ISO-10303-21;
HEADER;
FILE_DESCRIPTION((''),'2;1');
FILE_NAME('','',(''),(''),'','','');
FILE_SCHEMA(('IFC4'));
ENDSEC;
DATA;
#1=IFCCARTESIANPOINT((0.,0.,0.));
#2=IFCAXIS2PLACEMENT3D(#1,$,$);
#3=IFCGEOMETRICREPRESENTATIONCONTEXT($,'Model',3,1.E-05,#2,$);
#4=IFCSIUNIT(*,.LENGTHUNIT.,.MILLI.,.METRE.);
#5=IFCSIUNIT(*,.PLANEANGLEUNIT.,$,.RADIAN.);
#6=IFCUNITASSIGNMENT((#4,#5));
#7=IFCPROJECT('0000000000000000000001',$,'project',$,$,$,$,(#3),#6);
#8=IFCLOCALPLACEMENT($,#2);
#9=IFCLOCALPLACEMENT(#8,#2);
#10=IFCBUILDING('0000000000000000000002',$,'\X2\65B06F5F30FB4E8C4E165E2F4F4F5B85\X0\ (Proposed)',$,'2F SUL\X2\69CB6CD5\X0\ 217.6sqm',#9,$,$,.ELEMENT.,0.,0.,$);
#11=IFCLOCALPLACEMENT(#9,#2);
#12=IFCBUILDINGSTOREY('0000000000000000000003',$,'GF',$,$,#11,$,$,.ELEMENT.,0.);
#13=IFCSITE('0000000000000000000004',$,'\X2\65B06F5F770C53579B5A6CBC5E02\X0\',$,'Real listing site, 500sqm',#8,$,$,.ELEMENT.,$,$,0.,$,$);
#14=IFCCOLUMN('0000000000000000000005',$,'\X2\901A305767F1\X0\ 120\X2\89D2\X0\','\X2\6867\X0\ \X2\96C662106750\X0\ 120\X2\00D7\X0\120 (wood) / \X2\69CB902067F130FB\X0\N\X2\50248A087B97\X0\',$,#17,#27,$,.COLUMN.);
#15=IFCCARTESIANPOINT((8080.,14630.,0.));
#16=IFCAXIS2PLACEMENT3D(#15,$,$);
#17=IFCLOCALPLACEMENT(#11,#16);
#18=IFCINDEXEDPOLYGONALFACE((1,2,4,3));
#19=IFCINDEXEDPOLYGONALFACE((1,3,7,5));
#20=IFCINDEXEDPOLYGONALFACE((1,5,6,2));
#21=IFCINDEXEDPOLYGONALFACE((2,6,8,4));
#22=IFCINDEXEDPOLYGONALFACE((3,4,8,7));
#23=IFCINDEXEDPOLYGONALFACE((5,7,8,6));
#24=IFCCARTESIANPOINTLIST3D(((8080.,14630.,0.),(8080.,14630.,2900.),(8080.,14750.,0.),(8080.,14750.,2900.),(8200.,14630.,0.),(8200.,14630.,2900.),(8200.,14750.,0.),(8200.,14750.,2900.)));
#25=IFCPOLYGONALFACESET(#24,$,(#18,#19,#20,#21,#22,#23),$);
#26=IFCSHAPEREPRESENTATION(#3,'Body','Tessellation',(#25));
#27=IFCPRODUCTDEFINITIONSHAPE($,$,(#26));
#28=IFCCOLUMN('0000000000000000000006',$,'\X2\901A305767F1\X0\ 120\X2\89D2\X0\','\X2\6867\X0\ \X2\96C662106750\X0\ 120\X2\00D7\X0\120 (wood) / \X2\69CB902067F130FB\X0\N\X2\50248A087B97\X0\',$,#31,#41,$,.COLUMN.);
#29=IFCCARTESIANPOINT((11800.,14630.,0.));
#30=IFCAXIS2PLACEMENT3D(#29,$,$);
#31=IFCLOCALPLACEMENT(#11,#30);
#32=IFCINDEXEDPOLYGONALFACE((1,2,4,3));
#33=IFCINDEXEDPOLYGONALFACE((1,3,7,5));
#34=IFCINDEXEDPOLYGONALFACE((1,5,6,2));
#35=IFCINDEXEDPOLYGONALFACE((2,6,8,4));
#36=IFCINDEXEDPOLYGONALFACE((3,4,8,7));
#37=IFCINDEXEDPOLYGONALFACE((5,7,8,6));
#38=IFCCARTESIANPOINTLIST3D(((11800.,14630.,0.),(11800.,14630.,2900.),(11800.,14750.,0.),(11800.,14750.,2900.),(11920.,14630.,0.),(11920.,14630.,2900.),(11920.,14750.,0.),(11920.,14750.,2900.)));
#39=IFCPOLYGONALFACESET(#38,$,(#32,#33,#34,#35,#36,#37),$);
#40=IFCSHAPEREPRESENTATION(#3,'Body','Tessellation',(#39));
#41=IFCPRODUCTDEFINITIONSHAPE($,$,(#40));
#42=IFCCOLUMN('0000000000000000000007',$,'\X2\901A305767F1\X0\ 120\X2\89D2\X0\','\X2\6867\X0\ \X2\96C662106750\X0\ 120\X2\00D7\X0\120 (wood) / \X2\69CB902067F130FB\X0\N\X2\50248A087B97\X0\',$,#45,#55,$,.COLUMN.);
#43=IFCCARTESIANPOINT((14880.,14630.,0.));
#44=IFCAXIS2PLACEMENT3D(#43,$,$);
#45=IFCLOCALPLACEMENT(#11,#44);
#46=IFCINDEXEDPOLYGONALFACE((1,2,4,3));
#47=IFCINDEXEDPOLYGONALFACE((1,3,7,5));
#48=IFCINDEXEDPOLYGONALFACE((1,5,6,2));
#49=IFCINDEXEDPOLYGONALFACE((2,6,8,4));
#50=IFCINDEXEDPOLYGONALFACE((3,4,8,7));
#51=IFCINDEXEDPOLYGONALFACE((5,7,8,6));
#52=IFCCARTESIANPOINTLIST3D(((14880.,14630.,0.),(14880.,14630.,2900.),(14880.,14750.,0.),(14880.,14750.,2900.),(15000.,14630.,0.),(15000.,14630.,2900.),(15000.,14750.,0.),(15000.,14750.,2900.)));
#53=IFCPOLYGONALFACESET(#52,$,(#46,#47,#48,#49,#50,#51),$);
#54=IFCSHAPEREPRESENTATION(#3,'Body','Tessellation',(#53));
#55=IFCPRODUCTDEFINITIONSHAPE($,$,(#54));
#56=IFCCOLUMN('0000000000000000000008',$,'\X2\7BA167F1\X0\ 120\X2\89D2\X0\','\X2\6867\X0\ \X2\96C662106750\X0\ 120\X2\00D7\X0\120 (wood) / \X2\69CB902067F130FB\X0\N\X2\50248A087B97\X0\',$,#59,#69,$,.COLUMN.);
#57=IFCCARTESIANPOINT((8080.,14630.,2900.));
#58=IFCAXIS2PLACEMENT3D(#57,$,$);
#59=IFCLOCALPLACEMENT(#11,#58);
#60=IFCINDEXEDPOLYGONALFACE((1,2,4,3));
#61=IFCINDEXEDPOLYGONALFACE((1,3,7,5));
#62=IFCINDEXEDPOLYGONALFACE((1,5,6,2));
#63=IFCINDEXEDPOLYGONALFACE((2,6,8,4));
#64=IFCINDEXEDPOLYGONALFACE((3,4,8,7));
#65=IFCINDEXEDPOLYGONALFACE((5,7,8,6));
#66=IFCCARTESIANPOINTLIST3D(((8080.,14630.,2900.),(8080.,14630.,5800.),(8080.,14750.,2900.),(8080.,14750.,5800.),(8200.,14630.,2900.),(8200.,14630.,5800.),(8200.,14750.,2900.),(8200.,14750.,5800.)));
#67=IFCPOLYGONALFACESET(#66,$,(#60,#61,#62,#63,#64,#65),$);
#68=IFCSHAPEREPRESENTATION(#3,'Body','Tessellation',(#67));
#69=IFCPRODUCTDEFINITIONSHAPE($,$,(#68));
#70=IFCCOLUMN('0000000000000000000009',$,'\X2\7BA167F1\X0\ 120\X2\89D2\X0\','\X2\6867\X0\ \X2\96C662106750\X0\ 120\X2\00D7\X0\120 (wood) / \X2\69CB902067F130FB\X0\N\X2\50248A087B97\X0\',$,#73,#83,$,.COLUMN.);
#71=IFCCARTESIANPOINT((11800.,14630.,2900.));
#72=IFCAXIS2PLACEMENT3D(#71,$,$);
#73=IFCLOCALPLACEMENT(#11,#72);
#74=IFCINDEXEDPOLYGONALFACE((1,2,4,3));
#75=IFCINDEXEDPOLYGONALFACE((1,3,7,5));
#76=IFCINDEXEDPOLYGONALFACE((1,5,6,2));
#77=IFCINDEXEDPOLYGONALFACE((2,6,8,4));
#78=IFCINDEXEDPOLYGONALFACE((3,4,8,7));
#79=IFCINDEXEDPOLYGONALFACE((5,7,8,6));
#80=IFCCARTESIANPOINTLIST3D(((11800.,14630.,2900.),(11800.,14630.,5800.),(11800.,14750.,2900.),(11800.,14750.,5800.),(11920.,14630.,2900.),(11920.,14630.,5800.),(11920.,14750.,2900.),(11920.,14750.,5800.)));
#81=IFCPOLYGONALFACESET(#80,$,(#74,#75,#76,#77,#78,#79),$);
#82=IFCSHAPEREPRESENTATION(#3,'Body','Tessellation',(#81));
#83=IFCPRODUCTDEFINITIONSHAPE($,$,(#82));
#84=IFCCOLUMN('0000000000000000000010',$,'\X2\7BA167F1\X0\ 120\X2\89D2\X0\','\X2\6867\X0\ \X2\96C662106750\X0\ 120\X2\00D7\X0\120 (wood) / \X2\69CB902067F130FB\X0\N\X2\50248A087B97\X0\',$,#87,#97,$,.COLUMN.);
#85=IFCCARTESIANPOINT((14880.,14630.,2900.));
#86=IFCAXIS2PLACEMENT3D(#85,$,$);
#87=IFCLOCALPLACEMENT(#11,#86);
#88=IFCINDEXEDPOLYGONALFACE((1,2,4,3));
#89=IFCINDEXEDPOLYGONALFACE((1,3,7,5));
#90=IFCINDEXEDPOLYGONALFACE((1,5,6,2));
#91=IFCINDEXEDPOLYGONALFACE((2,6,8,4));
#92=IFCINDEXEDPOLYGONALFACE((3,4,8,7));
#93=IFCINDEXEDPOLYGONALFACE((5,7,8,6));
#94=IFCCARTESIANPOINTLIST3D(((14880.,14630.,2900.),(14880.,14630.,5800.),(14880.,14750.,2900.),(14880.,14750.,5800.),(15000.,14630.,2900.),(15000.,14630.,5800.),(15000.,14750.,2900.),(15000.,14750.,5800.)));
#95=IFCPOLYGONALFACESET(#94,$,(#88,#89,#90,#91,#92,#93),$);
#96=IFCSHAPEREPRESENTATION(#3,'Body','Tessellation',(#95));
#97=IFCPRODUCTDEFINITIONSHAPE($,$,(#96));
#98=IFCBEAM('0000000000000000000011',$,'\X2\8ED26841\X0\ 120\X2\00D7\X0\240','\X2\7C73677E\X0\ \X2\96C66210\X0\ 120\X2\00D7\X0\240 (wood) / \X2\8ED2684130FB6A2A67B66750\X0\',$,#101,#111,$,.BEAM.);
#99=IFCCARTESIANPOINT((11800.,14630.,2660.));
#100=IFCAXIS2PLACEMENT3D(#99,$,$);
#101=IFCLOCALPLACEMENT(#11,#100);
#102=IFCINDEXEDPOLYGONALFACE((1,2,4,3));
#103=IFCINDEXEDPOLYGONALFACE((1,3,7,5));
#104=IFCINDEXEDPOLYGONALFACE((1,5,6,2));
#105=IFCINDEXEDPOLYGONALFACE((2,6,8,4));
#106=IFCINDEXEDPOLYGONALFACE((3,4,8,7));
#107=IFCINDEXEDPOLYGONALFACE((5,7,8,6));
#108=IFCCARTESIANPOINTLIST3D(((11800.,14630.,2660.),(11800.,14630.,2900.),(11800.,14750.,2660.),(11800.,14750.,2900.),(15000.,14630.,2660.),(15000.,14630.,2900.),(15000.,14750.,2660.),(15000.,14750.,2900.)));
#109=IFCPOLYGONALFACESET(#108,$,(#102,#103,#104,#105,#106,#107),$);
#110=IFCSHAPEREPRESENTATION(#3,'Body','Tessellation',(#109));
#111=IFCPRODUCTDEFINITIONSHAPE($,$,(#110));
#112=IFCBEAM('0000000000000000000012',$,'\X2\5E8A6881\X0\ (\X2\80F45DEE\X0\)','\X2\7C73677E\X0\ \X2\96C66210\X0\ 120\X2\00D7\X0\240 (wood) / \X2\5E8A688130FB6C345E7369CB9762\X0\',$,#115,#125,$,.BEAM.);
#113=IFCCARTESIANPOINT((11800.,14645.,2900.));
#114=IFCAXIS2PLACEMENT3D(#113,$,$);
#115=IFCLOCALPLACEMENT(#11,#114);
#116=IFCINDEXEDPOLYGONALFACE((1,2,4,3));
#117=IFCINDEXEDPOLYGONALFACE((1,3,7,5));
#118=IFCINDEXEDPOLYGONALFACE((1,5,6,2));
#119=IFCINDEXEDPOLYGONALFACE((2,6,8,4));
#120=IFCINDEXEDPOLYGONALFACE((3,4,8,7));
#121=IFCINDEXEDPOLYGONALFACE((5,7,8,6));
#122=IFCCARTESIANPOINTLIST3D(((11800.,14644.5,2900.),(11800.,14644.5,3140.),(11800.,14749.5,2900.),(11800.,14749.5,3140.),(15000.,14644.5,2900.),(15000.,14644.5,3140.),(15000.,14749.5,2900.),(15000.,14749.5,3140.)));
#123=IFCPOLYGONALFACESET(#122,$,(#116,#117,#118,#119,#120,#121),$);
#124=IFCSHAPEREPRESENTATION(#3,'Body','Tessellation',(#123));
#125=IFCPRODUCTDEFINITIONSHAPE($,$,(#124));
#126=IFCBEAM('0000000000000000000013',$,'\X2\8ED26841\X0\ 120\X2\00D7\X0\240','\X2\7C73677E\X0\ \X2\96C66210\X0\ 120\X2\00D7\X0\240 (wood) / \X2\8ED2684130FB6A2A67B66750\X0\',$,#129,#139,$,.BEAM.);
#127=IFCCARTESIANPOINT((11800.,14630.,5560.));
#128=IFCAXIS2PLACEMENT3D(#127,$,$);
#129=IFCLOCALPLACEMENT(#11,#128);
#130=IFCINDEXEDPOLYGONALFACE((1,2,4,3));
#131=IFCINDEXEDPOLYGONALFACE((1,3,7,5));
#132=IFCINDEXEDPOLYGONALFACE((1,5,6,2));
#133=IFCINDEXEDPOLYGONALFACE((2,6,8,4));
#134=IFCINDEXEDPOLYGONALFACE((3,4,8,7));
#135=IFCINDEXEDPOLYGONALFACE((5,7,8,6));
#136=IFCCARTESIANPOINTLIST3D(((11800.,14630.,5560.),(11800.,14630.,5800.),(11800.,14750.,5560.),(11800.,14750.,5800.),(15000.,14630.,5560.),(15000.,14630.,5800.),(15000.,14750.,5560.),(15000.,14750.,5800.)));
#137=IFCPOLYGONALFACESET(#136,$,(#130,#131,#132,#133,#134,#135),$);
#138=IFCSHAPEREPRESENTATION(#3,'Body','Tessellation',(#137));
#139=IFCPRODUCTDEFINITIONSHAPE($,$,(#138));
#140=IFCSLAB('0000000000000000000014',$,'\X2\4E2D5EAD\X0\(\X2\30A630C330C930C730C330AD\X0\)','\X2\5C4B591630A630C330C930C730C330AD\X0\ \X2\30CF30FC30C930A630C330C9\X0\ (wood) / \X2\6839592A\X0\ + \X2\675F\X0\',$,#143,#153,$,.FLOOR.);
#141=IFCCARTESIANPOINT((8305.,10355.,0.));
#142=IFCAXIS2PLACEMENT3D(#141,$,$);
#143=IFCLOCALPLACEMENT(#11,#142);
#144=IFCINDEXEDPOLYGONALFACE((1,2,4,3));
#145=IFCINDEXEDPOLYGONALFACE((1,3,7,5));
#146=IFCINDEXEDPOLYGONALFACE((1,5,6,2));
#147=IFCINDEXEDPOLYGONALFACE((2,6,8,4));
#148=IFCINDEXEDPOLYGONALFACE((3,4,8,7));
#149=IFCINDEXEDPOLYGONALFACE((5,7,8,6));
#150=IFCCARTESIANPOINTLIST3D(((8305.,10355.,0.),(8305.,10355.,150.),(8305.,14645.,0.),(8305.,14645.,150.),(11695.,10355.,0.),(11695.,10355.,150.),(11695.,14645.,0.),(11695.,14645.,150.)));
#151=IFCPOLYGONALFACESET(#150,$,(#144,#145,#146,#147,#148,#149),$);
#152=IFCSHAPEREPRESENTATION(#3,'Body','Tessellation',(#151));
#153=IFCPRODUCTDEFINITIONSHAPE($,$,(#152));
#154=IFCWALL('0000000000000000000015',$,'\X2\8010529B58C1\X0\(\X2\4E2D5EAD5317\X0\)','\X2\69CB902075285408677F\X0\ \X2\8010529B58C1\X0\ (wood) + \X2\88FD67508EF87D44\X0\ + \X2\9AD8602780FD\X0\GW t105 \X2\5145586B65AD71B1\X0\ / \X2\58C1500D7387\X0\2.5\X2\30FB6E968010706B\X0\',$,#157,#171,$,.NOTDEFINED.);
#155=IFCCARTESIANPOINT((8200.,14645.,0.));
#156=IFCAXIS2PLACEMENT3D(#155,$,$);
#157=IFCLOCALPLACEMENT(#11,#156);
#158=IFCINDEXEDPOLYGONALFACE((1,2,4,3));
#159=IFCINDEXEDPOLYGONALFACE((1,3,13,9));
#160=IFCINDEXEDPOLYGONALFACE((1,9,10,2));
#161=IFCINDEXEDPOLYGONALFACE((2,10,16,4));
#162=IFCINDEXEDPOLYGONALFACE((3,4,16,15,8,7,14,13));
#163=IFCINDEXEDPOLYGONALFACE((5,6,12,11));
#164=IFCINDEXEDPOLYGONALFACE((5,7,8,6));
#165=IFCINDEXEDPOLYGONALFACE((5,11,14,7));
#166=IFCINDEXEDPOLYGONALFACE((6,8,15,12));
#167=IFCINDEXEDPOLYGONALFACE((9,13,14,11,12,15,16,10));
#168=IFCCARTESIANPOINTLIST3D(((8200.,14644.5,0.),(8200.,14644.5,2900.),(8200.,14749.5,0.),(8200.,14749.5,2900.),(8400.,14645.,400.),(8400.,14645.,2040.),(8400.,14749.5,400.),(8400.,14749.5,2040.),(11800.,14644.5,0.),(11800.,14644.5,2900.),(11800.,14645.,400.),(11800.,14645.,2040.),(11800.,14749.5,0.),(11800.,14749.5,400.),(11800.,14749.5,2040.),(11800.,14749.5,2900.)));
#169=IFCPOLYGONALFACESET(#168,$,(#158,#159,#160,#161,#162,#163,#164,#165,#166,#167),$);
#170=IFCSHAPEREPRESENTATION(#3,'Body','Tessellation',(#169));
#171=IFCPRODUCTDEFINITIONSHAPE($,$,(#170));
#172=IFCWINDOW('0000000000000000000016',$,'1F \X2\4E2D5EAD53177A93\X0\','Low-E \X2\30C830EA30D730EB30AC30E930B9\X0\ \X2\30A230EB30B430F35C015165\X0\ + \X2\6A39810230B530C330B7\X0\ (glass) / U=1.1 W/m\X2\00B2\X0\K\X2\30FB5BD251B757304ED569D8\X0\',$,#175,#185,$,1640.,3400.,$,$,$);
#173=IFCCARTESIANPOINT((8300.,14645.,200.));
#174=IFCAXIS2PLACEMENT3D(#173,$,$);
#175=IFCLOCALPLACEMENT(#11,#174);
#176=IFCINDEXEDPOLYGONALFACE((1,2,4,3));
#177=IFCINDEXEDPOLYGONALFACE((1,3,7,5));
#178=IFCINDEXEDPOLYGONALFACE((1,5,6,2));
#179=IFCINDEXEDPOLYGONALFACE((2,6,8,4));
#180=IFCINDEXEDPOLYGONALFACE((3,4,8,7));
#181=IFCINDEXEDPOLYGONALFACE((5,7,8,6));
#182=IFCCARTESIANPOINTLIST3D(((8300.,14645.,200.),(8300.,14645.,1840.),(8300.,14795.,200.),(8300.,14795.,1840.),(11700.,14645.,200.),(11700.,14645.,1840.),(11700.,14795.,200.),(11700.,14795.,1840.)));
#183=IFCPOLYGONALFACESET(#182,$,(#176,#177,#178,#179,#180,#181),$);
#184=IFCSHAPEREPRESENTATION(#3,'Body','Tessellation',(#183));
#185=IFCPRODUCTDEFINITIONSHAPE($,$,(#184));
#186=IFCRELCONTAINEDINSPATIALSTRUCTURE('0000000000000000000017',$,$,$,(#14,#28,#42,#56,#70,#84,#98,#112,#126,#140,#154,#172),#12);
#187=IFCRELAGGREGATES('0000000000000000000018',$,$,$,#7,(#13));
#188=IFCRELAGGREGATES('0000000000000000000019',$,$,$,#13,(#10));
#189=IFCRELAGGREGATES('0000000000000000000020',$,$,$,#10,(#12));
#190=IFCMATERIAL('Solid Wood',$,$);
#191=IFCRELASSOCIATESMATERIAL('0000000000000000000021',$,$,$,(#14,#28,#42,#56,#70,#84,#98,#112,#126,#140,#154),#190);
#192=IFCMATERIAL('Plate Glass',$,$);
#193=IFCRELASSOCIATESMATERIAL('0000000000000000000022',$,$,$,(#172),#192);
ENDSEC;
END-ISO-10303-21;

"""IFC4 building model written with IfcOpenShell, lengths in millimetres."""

from ifc_helpers import new_model, si_unit, frame, frame_2d, origin, place, context, project, spatial, rectangle, extrude, material, element, fill, save


model = new_model("IFC4")

# Units and contexts
model_context = context("Model", 3, precision=1e-05, world=origin())
ifc_project = project(units=[si_unit("LENGTHUNIT", "METRE", prefix="MILLI"), si_unit("PLANEANGLEUNIT", "RADIAN")], contexts=[model_context])

# Site, building, storey
site_placement = place(None, origin())
site = spatial("IfcSite", under=ifc_project, at=site_placement, Name="新潟県南魚沼市", ObjectType="Real listing site, 500sqm", CompositionType="ELEMENT", RefElevation=0.0)
building_placement = place(site_placement, origin())
building = spatial("IfcBuilding", under=site, at=building_placement, Name="新潟・二世帯住宅 (Proposed)", ObjectType="2F SUL構法 217.6sqm", CompositionType="ELEMENT", ElevationOfRefHeight=0.0, ElevationOfTerrain=0.0)
storey_placement = place(building_placement, origin())
storey = spatial("IfcBuildingStorey", under=building, at=storey_placement, Name="GF", CompositionType="ELEMENT", Elevation=0.0)

# Columns
ifc_material_1 = material(Name="Solid Wood")
column_1_placement = place(storey_placement, frame((8080.0, 14630.0, 0.0)))
element("IfcColumn", 1, at=column_1_placement, inside=storey, material=ifc_material_1, Name="通し柱 120角", Description="桧 集成材 120×120 (wood) / 構造柱・N値計算", PredefinedType="COLUMN", context=model_context, shape_type="SweptSolid", body=[
    extrude(rectangle(XDim=120.0, YDim=120.0, at=frame_2d((60.0, 60.0))), frame((8080.0, 14630.0, 0.0)), (0.0, 0.0, 1.0), 2900.0),
])
column_2_placement = place(storey_placement, frame((11800.0, 14630.0, 0.0)))
element("IfcColumn", 2, at=column_2_placement, inside=storey, material=ifc_material_1, Name="通し柱 120角", Description="桧 集成材 120×120 (wood) / 構造柱・N値計算", PredefinedType="COLUMN", context=model_context, shape_type="SweptSolid", body=[
    extrude(rectangle(XDim=120.0, YDim=120.0, at=frame_2d((60.0, 60.0))), frame((11800.0, 14630.0, 0.0)), (0.0, 0.0, 1.0), 2900.0),
])
column_3_placement = place(storey_placement, frame((14880.0, 14630.0, 0.0)))
element("IfcColumn", 3, at=column_3_placement, inside=storey, material=ifc_material_1, Name="通し柱 120角", Description="桧 集成材 120×120 (wood) / 構造柱・N値計算", PredefinedType="COLUMN", context=model_context, shape_type="SweptSolid", body=[
    extrude(rectangle(XDim=120.0, YDim=120.0, at=frame_2d((60.0, 60.0))), frame((14880.0, 14630.0, 0.0)), (0.0, 0.0, 1.0), 2900.0),
])
column_4_placement = place(storey_placement, frame((8080.0, 14630.0, 2900.0)))
element("IfcColumn", 4, at=column_4_placement, inside=storey, material=ifc_material_1, Name="管柱 120角", Description="桧 集成材 120×120 (wood) / 構造柱・N値計算", PredefinedType="COLUMN", context=model_context, shape_type="SweptSolid", body=[
    extrude(rectangle(XDim=120.0, YDim=120.0, at=frame_2d((60.0, 60.0))), frame((8080.0, 14630.0, 2900.0)), (0.0, 0.0, 1.0), 2900.0),
])
column_5_placement = place(storey_placement, frame((11800.0, 14630.0, 2900.0)))
element("IfcColumn", 5, at=column_5_placement, inside=storey, material=ifc_material_1, Name="管柱 120角", Description="桧 集成材 120×120 (wood) / 構造柱・N値計算", PredefinedType="COLUMN", context=model_context, shape_type="SweptSolid", body=[
    extrude(rectangle(XDim=120.0, YDim=120.0, at=frame_2d((60.0, 60.0))), frame((11800.0, 14630.0, 2900.0)), (0.0, 0.0, 1.0), 2900.0),
])
column_6_placement = place(storey_placement, frame((14880.0, 14630.0, 2900.0)))
element("IfcColumn", 6, at=column_6_placement, inside=storey, material=ifc_material_1, Name="管柱 120角", Description="桧 集成材 120×120 (wood) / 構造柱・N値計算", PredefinedType="COLUMN", context=model_context, shape_type="SweptSolid", body=[
    extrude(rectangle(XDim=120.0, YDim=120.0, at=frame_2d((60.0, 60.0))), frame((14880.0, 14630.0, 2900.0)), (0.0, 0.0, 1.0), 2900.0),
])

# Beams
beam_1_placement = place(storey_placement, frame((11800.0, 14630.0, 2660.0)))
element("IfcBeam", 7, at=beam_1_placement, inside=storey, material=ifc_material_1, Name="軒桁 120×240", Description="米松 集成 120×240 (wood) / 軒桁・横架材", PredefinedType="BEAM", context=model_context, shape_type="SweptSolid", body=[
    extrude(rectangle(XDim=3200.0, YDim=120.0, at=frame_2d((1600.0, 60.0))), frame((11800.0, 14630.0, 2660.0)), (0.0, 0.0, 1.0), 240.0),
])
beam_2_placement = place(storey_placement, frame((11800.0, 14645.0, 2900.0)))
element("IfcBeam", 8, at=beam_2_placement, inside=storey, material=ifc_material_1, Name="床梁 (胴差)", Description="米松 集成 120×240 (wood) / 床梁・水平構面", PredefinedType="BEAM", context=model_context, shape_type="SweptSolid", body=[
    extrude(rectangle(XDim=3200.0, YDim=105.0, at=frame_2d((1600.0, 52.0))), frame((11800.0, 14645.0, 2900.0)), (0.0, 0.0, 1.0), 240.0),
])
beam_3_placement = place(storey_placement, frame((11800.0, 14630.0, 5560.0)))
element("IfcBeam", 9, at=beam_3_placement, inside=storey, material=ifc_material_1, Name="軒桁 120×240", Description="米松 集成 120×240 (wood) / 軒桁・横架材", PredefinedType="BEAM", context=model_context, shape_type="SweptSolid", body=[
    extrude(rectangle(XDim=3200.0, YDim=120.0, at=frame_2d((1600.0, 60.0))), frame((11800.0, 14630.0, 5560.0)), (0.0, 0.0, 1.0), 240.0),
])

# Slab
slab_placement = place(storey_placement, frame((8305.0, 10355.0, 0.0)))
element("IfcSlab", 10, at=slab_placement, inside=storey, material=ifc_material_1, Name="中庭(ウッドデッキ)", Description="屋外ウッドデッキ ハードウッド (wood) / 根太 + 束", PredefinedType="FLOOR", context=model_context, shape_type="SweptSolid", body=[
    extrude(rectangle(XDim=3390.0, YDim=4290.0, at=frame_2d((1695.0, 2145.0))), frame((8305.0, 10355.0, 0.0)), (0.0, 0.0, 1.0), 150.0),
])

# Wall, opening, window
wall_1_placement = place(storey_placement, frame((8200.0, 14645.0, 0.0)))
wall_1 = element("IfcWall", 11, at=wall_1_placement, inside=storey, material=ifc_material_1, Name="耐力壁(中庭北)", Description="構造用合板 耐力壁 (wood) + 製材軸組 + 高性能GW t105 充填断熱 / 壁倍率2.5・準耐火", PredefinedType="NOTDEFINED", context=model_context, shape_type="SweptSolid", body=[
    extrude(rectangle(XDim=3600.0, YDim=105.0, at=frame_2d((1800.0, 52.0))), frame((8200.0, 14645.0, 0.0)), (0.0, 0.0, 1.0), 2900.0),
])
opening_1_placement = place(storey_placement, frame((8300.0, 14645.0, 200.0)))
opening_1 = element("IfcOpeningElement", 12, at=opening_1_placement, cuts=wall_1, PredefinedType="NOTDEFINED", context=model_context, shape_type="SweptSolid", body=[
    extrude(rectangle(XDim=3400.0, YDim=150.0, at=frame_2d((1700.0, 75.0))), frame((8300.0, 14645.0, 200.0)), (0.0, 0.0, 1.0), 1640.0),
])
ifc_material_2 = material(Name="Plate Glass")
window_1_placement = place(storey_placement, frame((8300.0, 14645.0, 200.0)))
window_1 = element("IfcWindow", 13, at=window_1_placement, inside=storey, material=ifc_material_2, Name="1F 中庭北窓", Description="Low-E トリプルガラス アルゴン封入 + 樹脂サッシ (glass) / U=1.1 W/m²K・寒冷地仕様", OverallHeight=1640.0, OverallWidth=3400.0, context=model_context, shape_type="SweptSolid", body=[
    extrude(rectangle(XDim=3400.0, YDim=150.0, at=frame_2d((1700.0, 75.0))), frame((8300.0, 14645.0, 200.0)), (0.0, 0.0, 1.0), 1640.0),
])
fill(opening_1, window_1)

save(model, "model.ifc")
